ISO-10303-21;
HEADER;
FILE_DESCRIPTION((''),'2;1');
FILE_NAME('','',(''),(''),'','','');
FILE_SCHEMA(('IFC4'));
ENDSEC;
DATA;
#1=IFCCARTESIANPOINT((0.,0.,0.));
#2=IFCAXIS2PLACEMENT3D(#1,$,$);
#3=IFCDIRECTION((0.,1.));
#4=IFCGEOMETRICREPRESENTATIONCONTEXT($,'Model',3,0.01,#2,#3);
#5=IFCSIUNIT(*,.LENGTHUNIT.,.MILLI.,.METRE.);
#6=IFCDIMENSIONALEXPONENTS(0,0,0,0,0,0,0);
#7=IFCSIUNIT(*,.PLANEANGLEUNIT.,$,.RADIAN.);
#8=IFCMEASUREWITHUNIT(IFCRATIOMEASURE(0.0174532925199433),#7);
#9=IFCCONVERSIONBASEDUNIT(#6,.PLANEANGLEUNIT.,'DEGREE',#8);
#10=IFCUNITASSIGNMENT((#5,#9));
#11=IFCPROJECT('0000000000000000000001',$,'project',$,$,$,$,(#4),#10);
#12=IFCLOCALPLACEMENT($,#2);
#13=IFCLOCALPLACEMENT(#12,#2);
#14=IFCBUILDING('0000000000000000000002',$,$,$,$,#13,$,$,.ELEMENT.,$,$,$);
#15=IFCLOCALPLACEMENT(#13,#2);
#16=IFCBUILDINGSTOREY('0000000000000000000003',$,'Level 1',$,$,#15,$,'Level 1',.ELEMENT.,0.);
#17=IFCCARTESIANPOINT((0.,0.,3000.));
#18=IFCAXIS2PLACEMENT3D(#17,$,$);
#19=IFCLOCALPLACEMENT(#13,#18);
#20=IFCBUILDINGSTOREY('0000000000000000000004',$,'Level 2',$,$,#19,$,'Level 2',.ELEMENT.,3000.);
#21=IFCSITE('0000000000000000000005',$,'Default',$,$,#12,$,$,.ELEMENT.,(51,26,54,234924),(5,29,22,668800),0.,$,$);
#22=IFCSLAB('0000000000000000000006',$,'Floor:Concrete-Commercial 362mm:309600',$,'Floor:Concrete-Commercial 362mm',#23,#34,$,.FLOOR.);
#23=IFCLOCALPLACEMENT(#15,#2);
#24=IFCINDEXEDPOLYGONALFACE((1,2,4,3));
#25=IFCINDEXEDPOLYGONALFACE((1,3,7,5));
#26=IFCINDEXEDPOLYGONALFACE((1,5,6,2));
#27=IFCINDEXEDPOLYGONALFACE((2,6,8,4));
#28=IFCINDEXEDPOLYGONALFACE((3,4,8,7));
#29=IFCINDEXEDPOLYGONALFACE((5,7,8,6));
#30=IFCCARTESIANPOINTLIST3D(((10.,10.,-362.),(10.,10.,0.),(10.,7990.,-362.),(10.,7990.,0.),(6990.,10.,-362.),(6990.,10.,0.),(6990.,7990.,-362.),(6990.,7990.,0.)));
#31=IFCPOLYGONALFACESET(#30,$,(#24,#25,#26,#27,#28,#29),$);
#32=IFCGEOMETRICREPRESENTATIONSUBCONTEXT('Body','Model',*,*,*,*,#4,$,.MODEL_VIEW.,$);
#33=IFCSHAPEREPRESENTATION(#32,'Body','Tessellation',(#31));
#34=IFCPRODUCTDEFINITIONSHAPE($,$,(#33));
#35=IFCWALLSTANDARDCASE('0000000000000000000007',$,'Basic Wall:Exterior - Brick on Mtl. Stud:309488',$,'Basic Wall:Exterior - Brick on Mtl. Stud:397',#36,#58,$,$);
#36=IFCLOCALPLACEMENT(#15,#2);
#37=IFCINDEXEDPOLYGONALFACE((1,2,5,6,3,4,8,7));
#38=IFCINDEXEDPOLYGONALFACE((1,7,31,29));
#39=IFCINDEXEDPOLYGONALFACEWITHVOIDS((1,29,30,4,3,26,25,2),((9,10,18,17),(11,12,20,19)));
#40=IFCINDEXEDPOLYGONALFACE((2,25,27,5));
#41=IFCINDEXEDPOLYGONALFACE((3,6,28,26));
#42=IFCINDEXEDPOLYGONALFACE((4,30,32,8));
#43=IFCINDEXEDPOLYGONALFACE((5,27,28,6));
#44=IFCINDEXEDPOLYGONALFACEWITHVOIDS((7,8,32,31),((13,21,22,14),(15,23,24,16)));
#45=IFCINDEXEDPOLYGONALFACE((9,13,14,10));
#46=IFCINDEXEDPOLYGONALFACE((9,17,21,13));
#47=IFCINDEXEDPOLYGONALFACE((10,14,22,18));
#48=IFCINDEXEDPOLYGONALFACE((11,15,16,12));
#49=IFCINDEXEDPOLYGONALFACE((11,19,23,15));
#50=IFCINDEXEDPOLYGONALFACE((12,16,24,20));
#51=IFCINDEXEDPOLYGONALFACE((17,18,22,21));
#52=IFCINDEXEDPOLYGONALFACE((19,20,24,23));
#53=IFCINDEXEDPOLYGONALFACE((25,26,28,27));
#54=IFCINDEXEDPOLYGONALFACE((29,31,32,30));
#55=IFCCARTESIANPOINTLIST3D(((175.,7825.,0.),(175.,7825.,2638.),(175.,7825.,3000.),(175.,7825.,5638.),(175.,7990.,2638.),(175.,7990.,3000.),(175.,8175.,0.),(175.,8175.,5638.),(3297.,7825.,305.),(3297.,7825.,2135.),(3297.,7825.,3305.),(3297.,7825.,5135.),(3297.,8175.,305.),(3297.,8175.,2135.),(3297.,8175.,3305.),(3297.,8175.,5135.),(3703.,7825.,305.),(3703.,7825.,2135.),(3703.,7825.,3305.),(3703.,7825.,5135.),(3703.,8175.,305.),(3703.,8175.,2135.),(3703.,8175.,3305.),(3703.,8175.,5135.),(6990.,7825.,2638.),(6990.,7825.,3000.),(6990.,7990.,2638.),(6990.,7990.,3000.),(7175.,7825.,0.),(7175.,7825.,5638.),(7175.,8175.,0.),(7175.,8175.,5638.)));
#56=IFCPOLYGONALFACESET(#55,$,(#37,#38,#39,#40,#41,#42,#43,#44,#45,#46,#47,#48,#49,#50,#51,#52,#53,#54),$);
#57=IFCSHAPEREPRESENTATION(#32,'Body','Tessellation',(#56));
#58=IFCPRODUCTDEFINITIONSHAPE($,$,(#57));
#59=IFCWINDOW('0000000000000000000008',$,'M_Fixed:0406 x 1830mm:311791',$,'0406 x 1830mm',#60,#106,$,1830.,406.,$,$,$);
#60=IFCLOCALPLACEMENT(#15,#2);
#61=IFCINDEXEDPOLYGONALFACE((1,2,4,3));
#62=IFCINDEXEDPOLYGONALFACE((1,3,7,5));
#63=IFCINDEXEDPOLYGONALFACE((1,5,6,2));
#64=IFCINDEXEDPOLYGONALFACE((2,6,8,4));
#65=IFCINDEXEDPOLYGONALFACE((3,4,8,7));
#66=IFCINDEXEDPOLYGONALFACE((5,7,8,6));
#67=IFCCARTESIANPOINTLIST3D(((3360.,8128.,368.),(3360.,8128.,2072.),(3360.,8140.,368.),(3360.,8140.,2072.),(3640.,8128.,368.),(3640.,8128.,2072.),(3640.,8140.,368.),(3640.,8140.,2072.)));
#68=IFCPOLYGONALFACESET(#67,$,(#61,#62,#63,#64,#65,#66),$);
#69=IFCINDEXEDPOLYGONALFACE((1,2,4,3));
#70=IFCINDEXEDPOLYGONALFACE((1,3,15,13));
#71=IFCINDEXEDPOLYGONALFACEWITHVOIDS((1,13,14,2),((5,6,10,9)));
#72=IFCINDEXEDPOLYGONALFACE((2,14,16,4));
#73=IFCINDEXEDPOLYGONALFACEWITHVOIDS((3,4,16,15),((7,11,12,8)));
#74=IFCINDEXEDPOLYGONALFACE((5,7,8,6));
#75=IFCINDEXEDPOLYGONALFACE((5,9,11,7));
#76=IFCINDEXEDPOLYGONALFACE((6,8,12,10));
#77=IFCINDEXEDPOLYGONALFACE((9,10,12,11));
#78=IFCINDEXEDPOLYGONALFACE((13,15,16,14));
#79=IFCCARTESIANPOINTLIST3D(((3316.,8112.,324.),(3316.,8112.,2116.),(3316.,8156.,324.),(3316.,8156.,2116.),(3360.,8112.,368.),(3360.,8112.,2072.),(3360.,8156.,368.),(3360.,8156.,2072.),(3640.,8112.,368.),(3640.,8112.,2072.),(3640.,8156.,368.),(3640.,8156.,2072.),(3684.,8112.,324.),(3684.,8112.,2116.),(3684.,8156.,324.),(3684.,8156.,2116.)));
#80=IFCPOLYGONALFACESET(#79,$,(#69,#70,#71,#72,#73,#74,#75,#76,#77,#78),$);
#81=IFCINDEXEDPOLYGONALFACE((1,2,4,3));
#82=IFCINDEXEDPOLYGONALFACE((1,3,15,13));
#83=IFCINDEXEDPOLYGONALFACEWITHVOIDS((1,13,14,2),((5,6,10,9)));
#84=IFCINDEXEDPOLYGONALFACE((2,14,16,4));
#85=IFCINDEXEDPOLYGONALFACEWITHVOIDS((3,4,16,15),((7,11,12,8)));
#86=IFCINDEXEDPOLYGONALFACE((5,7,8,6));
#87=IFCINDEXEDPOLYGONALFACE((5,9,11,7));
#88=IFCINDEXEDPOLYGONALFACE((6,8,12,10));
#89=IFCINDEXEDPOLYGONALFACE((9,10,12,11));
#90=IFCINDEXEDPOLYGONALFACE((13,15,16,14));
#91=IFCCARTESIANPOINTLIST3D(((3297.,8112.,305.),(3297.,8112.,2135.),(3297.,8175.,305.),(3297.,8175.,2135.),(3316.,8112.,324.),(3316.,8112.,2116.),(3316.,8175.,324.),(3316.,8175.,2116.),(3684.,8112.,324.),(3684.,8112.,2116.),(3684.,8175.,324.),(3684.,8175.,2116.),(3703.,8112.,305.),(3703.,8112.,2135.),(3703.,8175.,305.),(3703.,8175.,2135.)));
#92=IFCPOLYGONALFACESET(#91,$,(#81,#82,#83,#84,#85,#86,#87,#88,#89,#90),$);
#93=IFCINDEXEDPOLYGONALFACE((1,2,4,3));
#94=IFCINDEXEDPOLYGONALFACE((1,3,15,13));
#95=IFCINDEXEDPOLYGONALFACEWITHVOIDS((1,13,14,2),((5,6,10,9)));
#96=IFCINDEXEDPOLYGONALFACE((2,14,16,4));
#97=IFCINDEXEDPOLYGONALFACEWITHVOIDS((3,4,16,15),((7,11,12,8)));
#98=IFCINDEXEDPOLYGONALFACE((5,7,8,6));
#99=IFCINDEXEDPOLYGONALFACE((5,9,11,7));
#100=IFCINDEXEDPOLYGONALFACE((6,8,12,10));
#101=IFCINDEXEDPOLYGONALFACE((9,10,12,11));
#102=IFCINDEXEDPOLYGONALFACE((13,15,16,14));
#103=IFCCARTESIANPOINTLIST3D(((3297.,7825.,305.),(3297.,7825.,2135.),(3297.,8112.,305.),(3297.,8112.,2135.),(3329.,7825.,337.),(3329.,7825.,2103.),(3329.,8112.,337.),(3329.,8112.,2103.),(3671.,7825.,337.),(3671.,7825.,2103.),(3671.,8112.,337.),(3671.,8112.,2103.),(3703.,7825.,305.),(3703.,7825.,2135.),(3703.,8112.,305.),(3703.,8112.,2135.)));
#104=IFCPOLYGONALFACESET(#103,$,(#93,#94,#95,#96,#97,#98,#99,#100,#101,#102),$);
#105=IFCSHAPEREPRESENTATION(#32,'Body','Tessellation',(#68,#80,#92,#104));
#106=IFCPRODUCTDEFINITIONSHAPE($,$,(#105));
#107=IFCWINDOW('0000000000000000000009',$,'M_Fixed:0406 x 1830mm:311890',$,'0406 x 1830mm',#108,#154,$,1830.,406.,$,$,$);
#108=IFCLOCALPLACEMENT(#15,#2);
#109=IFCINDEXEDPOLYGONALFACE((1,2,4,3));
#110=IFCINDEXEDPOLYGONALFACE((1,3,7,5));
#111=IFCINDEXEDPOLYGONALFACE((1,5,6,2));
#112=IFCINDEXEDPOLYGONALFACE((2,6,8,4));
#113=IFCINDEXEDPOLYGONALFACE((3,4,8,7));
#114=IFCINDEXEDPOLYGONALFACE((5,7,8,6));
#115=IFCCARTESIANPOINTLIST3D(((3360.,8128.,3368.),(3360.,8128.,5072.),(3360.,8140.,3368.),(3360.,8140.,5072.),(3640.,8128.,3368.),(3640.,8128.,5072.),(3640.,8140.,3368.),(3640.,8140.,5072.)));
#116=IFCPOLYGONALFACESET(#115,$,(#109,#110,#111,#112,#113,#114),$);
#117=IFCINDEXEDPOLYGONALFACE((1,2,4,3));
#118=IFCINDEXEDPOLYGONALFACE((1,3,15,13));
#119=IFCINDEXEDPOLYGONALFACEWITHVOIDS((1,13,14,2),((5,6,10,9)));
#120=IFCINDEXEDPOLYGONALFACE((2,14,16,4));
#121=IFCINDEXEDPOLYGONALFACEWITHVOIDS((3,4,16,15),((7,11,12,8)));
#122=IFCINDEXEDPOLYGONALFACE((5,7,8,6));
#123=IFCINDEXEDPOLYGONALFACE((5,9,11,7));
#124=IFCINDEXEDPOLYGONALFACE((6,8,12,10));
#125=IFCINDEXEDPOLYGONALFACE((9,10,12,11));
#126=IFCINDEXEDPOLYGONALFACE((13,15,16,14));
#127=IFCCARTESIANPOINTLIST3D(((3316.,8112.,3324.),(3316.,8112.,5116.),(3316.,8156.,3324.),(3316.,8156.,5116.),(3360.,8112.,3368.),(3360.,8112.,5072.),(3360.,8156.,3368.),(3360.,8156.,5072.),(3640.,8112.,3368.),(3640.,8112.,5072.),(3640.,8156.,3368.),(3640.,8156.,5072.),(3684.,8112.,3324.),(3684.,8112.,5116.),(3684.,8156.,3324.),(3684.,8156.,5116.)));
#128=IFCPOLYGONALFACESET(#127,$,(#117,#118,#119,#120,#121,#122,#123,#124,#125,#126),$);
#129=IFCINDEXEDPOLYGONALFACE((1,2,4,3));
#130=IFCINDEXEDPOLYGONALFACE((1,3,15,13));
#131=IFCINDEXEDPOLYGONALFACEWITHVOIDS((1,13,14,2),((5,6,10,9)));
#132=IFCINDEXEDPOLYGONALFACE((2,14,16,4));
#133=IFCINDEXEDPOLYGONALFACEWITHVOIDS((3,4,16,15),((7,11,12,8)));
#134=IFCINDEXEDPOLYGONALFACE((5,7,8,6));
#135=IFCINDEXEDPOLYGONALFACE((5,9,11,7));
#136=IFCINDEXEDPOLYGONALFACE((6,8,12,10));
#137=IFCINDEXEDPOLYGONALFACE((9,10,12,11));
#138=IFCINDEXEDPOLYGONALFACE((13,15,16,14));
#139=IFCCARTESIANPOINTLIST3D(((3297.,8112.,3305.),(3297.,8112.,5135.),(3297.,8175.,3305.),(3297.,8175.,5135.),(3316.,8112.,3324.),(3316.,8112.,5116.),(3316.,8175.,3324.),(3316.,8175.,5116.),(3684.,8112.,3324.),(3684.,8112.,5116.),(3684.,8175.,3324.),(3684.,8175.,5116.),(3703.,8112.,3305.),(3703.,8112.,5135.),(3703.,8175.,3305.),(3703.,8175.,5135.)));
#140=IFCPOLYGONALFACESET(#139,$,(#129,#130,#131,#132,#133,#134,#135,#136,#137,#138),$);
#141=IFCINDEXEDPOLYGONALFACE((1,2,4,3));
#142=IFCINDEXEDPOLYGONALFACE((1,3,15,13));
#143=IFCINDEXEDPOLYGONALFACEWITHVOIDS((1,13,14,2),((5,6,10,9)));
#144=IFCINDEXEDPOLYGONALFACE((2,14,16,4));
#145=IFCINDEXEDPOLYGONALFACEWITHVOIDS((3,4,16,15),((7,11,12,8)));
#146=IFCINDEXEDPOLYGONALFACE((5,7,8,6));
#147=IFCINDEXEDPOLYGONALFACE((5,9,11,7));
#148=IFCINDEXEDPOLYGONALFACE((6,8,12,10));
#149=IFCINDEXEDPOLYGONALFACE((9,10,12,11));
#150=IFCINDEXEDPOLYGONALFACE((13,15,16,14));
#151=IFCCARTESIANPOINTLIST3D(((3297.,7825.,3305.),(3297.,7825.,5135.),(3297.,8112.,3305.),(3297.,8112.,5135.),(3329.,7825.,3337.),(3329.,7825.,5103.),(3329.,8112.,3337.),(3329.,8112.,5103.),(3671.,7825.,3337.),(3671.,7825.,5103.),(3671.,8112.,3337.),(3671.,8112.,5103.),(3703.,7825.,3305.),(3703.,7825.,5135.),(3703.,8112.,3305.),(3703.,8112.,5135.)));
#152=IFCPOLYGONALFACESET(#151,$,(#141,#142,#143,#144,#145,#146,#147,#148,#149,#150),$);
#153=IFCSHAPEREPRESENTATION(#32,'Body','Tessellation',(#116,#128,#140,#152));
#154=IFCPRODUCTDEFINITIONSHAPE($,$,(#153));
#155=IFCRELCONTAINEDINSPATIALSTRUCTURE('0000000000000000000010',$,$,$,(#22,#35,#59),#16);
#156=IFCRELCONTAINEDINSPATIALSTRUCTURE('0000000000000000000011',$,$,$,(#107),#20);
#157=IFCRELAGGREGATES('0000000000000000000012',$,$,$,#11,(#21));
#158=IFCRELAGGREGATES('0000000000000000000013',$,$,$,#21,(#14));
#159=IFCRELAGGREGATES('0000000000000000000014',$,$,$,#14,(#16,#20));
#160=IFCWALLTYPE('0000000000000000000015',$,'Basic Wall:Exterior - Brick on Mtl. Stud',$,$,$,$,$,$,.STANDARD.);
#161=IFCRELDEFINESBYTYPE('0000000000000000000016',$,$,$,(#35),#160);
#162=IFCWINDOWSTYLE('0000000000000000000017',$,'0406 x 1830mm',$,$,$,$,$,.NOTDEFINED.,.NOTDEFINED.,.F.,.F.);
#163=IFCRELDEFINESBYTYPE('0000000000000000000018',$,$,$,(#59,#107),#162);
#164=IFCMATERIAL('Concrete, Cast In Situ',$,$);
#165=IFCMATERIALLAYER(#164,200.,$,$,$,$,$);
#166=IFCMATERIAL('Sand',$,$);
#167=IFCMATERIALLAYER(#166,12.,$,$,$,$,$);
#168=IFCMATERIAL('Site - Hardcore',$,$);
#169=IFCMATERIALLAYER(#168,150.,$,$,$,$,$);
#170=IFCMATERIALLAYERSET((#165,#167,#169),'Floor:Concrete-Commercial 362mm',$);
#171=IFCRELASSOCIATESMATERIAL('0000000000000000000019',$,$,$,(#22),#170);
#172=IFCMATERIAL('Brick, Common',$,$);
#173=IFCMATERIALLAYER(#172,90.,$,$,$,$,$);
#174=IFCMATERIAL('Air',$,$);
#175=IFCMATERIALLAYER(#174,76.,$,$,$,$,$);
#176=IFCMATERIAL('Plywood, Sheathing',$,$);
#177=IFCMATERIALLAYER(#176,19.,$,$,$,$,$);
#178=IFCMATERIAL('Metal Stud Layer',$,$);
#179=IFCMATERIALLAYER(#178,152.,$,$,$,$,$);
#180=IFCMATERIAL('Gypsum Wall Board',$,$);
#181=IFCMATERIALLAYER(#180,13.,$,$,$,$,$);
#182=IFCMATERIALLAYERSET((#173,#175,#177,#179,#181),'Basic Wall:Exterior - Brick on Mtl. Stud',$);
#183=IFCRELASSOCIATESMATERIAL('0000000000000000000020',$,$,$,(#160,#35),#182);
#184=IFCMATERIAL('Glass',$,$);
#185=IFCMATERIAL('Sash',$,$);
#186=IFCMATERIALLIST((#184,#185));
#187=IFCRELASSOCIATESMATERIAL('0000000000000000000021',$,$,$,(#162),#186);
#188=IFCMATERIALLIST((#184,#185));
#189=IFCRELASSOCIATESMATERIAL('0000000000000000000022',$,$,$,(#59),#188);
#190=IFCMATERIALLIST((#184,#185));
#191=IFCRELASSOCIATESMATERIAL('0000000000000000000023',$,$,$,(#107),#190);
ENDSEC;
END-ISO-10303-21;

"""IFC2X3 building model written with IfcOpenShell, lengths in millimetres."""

from ifc_helpers import new_model, entity, si_unit, converted_unit, direction, frame, frame_2d, origin, place, context, subcontext, project, spatial, polyline, rectangle, outline, extrude, clip, bounded_halfspace, source, transform, mapped, material, material_list, layer, layer_set, layer_usage, type_object, type_shapes, element, fill, save


model = new_model("IFC2X3")

# Units and contexts
model_context = context("Model", 3, precision=0.01, world=origin(), true_north=direction((0.0, 1.0)))
body_context = subcontext(model_context, "Body", "Model", "MODEL_VIEW")
ifc_project = project(units=[si_unit("LENGTHUNIT", "METRE", prefix="MILLI"), converted_unit("PLANEANGLEUNIT", "DEGREE", entity("IfcRatioMeasure", 0.0174532925199433), si_unit("PLANEANGLEUNIT", "RADIAN"), dimensions=[0, 0, 0, 0, 0, 0, 0])], contexts=[model_context])

# Site, building, storey
site_placement = place(None, origin())
site = spatial("IfcSite", under=ifc_project, at=site_placement, Name="Default", CompositionType="ELEMENT", RefLatitude=(51, 26, 54, 234924), RefLongitude=(5, 29, 22, 668800), RefElevation=0.0)
building_placement = place(site_placement, origin())
building = spatial("IfcBuilding", under=site, at=building_placement, CompositionType="ELEMENT")
storey_1_placement = place(building_placement, origin())
storey_1 = spatial("IfcBuildingStorey", under=building, at=storey_1_placement, Name="Level 1", LongName="Level 1", CompositionType="ELEMENT", Elevation=0.0)

# Slab
ifc_material_1 = material(Name="Concrete, Cast In Situ")
ifc_layer_1 = layer(ifc_material_1, 200.0)
ifc_material_2 = material(Name="Sand")
ifc_layer_2 = layer(ifc_material_2, 12.0)
ifc_material_3 = material(Name="Site - Hardcore")
ifc_layer_3 = layer(ifc_material_3, 150.0)
ifc_layer_set_1 = layer_set([ifc_layer_1, ifc_layer_2, ifc_layer_3], Name="Floor:Concrete-Commercial 362mm")
ifc_layer_usage_1 = layer_usage(ifc_layer_set_1, "AXIS3", "POSITIVE", 0.0)
slab_placement = place(storey_1_placement, origin())
element("IfcSlab", 1, at=slab_placement, inside=storey_1, material=ifc_layer_usage_1, Name="Floor:Concrete-Commercial 362mm:309600", ObjectType="Floor:Concrete-Commercial 362mm", PredefinedType="FLOOR", context=body_context, shape_type="SweptSolid", body=[
    extrude(rectangle(XDim=7980.0, YDim=6980.0, at=frame_2d((0.0, 0.0), x_axis=(1.0, 0.0))), frame((3500.0, 4000.0, 0.0), z_axis=(0.0, 0.0, -1.0), x_axis=(0.0, 1.0, 0.0)), (0.0, 0.0, 1.0), 362.0),
])

# Shared definitions
ifc_material_4 = material(Name="Brick, Common")
ifc_layer_4 = layer(ifc_material_4, 90.0)
ifc_material_5 = material(Name="Air")
ifc_layer_5 = layer(ifc_material_5, 76.0)
ifc_material_6 = material(Name="Plywood, Sheathing")
ifc_layer_6 = layer(ifc_material_6, 19.0)
ifc_material_7 = material(Name="Metal Stud Layer")
ifc_layer_7 = layer(ifc_material_7, 152.0)
ifc_material_8 = material(Name="Gypsum Wall Board")
ifc_layer_8 = layer(ifc_material_8, 13.0)
ifc_layer_set_2 = layer_set([ifc_layer_4, ifc_layer_5, ifc_layer_6, ifc_layer_7, ifc_layer_8], Name="Basic Wall:Exterior - Brick on Mtl. Stud")
wall_type_1 = type_object("IfcWallType", Name="Basic Wall:Exterior - Brick on Mtl. Stud", PredefinedType="STANDARD", material=ifc_layer_set_2)
ifc_material_9 = material(Name="Glass")
ifc_material_10 = material(Name="Sash")

# Shared definitions
storey_2_placement = place(building_placement, frame((0.0, 0.0, 3000.0)))
storey_2 = spatial("IfcBuildingStorey", under=building, at=storey_2_placement, Name="Level 2", LongName="Level 2", CompositionType="ELEMENT", Elevation=3000.0)

# Wall, openings, windows
ifc_layer_usage_2 = layer_usage(ifc_layer_set_2, "AXIS2", "NEGATIVE", 175.0)
wall_1_placement = place(storey_1_placement, frame((175.0, 8000.0, 0.0)))
wall_1 = element("IfcWallStandardCase", 2, at=wall_1_placement, inside=storey_1, type_object=wall_type_1, material=ifc_layer_usage_2, Name="Basic Wall:Exterior - Brick on Mtl. Stud:309488", ObjectType="Basic Wall:Exterior - Brick on Mtl. Stud:397", context=body_context, shape_type="Clipping", body=[
    clip(extrude(rectangle(XDim=7000.0, YDim=350.0, at=frame_2d((3500.0, 0.0), x_axis=(-1.0, 0.0))), origin(), (0.0, 0.0, 1.0), 5638.0), bounded_halfspace(frame((0.0, -175.0, 5638.0), z_axis=(0.0, 0.0, -1.0), x_axis=(0.0, -1.0, 0.0)), True, frame((0.0, -175.0, 5638.0)), polyline([(0.0, 0.0), (2746.0, 0.0), (2825.0, 0.0), (3825.0, 0.0), (3904.0, 0.0), (6650.0, 0.0), (6815.0, 0.0), (6815.0, 165.0), (0.0, 165.0), (0.0, 0.0)]))),
])
opening_1_placement = place(storey_1_placement, frame((175.0, 8000.0, 0.0)))
element("IfcOpeningElement", 3, at=opening_1_placement, cuts=wall_1, ObjectType="Opening", context=body_context, shape_type="SweptSolid", body=[
    extrude(rectangle(XDim=6815.0, YDim=165.0, at=frame_2d((-41.2, -41.3), x_axis=(1.0, 0.0))), frame((3366.2, -133.8, 2638.0), z_axis=(0.0, 0.0, 1.0), x_axis=(-1.0, 0.0, 0.0)), (0.0, 0.0, 1.0), 362.0),
])
opening_2_placement = place(wall_1_placement, frame((3122.0, -175.0, 305.0)))
opening_2 = element("IfcOpeningElement", 4, at=opening_2_placement, cuts=wall_1, ObjectType="Opening", context=body_context, shape_type="SweptSolid", body=[
    extrude(rectangle(XDim=1830.0, YDim=406.0, at=frame_2d((915.0, 203.0), x_axis=(1.0, 0.0))), frame((0.0, 0.0, 0.0), z_axis=(0.0, 1.0, 0.0), x_axis=(0.0, 0.0, 1.0)), (0.0, 0.0, 1.0), 350.0),
])
opening_3_placement = place(wall_1_placement, frame((3122.0, -175.0, 3305.0)))
opening_3 = element("IfcOpeningElement", 5, at=opening_3_placement, cuts=wall_1, ObjectType="Opening", context=body_context, shape_type="SweptSolid", body=[
    extrude(rectangle(XDim=1830.0, YDim=406.0, at=frame_2d((915.0, 203.0), x_axis=(1.0, 0.0))), frame((0.0, 0.0, 0.0), z_axis=(0.0, 1.0, 0.0), x_axis=(0.0, 0.0, 1.0)), (0.0, 0.0, 1.0), 350.0),
])
ifc_material_list_1 = material_list([ifc_material_9, ifc_material_10])
ifc_material_list_2 = material_list([ifc_material_9, ifc_material_10])
window_style_1 = type_object("IfcWindowStyle", Name="0406 x 1830mm", ConstructionType="NOTDEFINED", OperationType="NOTDEFINED", ParameterTakesPrecedence=False, Sizeable=False, material=ifc_material_list_2)
shared_shape_1 = source(origin(), body_context, "Body", "SweptSolid", [
    extrude(rectangle(XDim=12.0, YDim=280.0, at=frame_2d((0.0, 0.0), x_axis=(1.0, 0.0))), frame((203.0, 309.0, 63.0), z_axis=(0.0, 0.0, 1.0), x_axis=(0.0, -1.0, 0.0)), (0.0, 0.0, 1.0), 1704.0),
    extrude(outline(polyline([(-184.0, -896.0), (184.0, -896.0), (184.0, 896.0), (-184.0, 896.0), (-184.0, -896.0)]), holes=[polyline([(-140.0, -852.0), (-140.0, 852.0), (140.0, 852.0), (140.0, -852.0), (-140.0, -852.0)])]), frame((203.0, 287.0, 915.0), z_axis=(0.0, 1.0, 0.0), x_axis=(1.0, 0.0, 0.0)), (0.0, 0.0, 1.0), 44.0),
    extrude(outline(polyline([(-203.0, -915.0), (203.0, -915.0), (203.0, 915.0), (-203.0, 915.0), (-203.0, -915.0)]), holes=[polyline([(-184.0, -896.0), (-184.0, 896.0), (184.0, 896.0), (184.0, -896.0), (-184.0, -896.0)])]), frame((203.0, 287.0, 915.0), z_axis=(0.0, 1.0, 0.0), x_axis=(1.0, 0.0, 0.0)), (0.0, 0.0, 1.0), 63.0),
    extrude(outline(polyline([(-203.0, -915.0), (203.0, -915.0), (203.0, 915.0), (-203.0, 915.0), (-203.0, -915.0)]), holes=[polyline([(-171.0, -883.0), (-171.0, 883.0), (171.0, 883.0), (171.0, -883.0), (-171.0, -883.0)])]), frame((203.0, 0.0, 915.0), z_axis=(0.0, 1.0, 0.0), x_axis=(1.0, 0.0, 0.0)), (0.0, 0.0, 1.0), 287.0),
])
type_shapes(window_style_1, [shared_shape_1])
window_1_placement = place(opening_2_placement, origin())
window_1 = element("IfcWindow", 6, at=window_1_placement, inside=storey_1, type_object=window_style_1, material=ifc_material_list_1, Name="M_Fixed:0406 x 1830mm:311791", ObjectType="0406 x 1830mm", OverallHeight=1830.0, OverallWidth=406.0, context=body_context, shape_type="MappedRepresentation", body=[
    mapped(shared_shape_1, transform((0.0, 0.0, 0.0), scale=1.0)),
])
fill(opening_2, window_1)
ifc_material_list_3 = material_list([ifc_material_9, ifc_material_10])
window_2_placement = place(opening_3_placement, origin())
window_2 = element("IfcWindow", 7, at=window_2_placement, inside=storey_2, type_object=window_style_1, material=ifc_material_list_3, Name="M_Fixed:0406 x 1830mm:311890", ObjectType="0406 x 1830mm", OverallHeight=1830.0, OverallWidth=406.0, context=body_context, shape_type="MappedRepresentation", body=[
    mapped(shared_shape_1, transform((0.0, 0.0, 0.0), scale=1.0)),
])
fill(opening_3, window_2)

save(model, "model.ifc")
